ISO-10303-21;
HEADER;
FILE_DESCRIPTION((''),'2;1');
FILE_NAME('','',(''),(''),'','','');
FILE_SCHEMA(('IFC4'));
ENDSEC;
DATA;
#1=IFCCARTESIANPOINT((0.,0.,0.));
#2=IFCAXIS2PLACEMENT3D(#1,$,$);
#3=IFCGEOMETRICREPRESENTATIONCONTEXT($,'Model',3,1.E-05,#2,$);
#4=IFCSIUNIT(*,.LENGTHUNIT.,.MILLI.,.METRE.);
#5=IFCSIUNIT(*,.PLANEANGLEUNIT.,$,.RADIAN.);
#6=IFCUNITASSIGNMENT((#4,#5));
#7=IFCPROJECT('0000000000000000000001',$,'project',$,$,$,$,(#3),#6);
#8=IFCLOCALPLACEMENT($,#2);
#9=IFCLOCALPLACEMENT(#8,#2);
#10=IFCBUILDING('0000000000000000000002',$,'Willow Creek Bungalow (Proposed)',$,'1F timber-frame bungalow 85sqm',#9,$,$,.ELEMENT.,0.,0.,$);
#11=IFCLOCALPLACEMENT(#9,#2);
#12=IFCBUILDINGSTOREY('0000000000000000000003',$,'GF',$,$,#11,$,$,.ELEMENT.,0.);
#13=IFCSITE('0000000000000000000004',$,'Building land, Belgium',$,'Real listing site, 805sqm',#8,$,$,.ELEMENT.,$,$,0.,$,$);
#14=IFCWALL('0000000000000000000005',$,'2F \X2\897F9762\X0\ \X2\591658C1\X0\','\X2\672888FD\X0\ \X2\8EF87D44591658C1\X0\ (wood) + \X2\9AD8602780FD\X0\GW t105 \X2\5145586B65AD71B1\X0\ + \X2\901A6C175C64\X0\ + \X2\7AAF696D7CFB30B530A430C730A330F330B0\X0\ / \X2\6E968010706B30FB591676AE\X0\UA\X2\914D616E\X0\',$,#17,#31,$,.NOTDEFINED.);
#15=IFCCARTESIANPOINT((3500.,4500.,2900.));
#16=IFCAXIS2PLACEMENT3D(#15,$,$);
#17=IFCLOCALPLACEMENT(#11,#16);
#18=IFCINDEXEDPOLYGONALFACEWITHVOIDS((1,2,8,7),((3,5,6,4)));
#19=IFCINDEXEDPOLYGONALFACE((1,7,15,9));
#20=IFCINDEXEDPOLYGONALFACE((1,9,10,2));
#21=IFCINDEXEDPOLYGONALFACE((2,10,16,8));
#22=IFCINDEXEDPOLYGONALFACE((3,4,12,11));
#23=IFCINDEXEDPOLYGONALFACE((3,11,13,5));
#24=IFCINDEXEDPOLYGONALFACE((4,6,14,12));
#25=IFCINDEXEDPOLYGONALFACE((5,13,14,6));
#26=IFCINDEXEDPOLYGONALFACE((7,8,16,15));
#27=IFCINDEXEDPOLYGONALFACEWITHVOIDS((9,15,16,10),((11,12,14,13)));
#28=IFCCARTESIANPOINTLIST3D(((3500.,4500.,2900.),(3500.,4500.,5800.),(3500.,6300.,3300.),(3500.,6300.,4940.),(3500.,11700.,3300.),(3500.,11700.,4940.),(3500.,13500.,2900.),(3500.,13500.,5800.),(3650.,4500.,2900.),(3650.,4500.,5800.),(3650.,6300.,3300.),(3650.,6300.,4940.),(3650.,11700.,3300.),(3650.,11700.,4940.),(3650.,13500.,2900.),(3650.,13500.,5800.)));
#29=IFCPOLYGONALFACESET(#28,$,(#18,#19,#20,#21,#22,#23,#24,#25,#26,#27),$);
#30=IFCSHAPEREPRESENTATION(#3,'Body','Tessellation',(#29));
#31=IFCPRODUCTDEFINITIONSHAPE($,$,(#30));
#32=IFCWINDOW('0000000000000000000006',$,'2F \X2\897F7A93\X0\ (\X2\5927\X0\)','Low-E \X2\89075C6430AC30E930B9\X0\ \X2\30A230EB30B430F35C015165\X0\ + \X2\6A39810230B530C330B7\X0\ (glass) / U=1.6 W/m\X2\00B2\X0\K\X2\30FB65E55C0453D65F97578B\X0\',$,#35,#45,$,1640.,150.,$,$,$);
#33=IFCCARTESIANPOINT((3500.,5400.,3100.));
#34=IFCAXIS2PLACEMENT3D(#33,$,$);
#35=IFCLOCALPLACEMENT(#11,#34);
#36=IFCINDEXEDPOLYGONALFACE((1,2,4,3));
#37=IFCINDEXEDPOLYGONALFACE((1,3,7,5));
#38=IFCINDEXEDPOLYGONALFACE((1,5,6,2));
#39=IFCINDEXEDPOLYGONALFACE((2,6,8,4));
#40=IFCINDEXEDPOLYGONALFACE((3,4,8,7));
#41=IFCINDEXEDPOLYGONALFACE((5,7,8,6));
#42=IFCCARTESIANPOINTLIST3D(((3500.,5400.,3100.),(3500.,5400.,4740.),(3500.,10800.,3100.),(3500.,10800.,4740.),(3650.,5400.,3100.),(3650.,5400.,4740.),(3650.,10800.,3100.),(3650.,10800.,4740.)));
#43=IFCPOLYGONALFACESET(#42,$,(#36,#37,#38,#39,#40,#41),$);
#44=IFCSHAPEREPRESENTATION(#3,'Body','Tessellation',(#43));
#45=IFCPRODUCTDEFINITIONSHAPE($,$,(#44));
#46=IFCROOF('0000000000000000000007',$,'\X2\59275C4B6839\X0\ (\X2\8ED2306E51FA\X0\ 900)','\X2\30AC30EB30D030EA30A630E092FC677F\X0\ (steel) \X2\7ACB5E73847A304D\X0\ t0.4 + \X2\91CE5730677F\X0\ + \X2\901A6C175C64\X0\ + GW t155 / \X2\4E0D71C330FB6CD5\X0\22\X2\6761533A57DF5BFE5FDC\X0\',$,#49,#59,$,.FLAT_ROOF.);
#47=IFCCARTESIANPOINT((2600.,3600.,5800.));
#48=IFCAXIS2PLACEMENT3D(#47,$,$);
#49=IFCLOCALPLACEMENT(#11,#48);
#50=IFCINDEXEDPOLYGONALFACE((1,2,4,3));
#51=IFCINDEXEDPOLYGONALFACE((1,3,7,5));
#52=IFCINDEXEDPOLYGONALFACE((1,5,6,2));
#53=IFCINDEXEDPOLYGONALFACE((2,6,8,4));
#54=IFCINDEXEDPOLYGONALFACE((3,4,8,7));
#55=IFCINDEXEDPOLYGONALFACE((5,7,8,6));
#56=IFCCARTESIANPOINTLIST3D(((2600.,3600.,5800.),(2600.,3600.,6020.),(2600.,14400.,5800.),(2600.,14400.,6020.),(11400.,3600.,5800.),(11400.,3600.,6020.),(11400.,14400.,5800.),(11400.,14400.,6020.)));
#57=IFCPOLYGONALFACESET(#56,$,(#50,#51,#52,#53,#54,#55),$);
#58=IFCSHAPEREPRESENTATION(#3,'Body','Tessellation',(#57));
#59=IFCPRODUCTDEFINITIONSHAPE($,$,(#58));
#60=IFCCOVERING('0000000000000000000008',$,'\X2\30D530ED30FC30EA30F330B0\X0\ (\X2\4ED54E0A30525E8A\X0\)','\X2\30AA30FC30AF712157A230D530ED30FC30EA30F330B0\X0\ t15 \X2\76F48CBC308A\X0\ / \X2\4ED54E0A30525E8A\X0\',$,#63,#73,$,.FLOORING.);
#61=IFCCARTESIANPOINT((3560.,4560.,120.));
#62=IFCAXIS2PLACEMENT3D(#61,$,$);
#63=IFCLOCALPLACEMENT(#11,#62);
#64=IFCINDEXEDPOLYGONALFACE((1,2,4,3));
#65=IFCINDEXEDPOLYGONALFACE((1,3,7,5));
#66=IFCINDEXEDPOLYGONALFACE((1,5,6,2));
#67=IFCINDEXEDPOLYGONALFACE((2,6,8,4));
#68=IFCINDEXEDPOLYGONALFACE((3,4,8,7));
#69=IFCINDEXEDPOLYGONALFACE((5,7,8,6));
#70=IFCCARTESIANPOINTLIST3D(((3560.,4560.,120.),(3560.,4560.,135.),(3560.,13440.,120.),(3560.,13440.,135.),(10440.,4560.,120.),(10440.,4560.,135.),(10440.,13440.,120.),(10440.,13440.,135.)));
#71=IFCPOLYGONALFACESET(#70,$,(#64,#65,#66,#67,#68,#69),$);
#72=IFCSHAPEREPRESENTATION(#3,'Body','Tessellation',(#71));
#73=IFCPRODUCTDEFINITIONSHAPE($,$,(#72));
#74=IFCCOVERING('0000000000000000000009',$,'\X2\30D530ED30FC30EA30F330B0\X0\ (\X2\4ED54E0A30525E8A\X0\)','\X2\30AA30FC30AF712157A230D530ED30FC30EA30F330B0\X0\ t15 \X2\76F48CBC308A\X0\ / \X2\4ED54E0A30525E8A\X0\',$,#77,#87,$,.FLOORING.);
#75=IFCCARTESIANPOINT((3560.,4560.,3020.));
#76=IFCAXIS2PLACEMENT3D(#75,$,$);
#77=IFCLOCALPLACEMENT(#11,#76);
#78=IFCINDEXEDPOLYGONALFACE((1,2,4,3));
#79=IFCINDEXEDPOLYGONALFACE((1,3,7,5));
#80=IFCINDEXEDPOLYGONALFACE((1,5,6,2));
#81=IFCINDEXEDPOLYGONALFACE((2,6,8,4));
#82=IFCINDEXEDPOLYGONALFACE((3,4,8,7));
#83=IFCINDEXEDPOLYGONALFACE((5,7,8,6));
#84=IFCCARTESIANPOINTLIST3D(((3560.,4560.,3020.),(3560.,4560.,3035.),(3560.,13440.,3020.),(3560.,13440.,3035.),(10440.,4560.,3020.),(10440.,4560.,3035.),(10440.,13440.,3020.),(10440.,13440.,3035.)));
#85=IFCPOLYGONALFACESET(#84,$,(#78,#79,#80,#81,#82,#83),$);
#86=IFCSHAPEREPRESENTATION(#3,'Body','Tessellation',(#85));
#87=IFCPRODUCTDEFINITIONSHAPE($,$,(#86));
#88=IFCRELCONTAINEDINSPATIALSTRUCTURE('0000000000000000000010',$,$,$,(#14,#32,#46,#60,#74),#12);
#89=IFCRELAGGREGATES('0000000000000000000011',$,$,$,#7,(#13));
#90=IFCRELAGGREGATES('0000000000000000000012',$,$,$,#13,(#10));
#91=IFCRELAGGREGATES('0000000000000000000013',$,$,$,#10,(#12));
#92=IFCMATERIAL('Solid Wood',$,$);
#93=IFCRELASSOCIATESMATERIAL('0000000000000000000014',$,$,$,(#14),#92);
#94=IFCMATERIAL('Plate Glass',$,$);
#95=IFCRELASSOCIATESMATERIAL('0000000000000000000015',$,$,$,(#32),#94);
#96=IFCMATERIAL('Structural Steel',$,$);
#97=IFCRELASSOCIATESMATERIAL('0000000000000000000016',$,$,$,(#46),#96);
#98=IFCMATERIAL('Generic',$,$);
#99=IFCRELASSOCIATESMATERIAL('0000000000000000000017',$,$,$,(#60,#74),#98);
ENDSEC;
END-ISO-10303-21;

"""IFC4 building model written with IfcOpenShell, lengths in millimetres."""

from ifc_helpers import new_model, si_unit, frame, frame_2d, origin, place, context, project, spatial, rectangle, extrude, material, element, fill, save


model = new_model("IFC4")

# Units and contexts
model_context = context("Model", 3, precision=1e-05, world=origin())
ifc_project = project(units=[si_unit("LENGTHUNIT", "METRE", prefix="MILLI"), si_unit("PLANEANGLEUNIT", "RADIAN")], contexts=[model_context])

# Site, building, storey
site_placement = place(None, origin())
site = spatial("IfcSite", under=ifc_project, at=site_placement, Name="Building land, Belgium", ObjectType="Real listing site, 805sqm", CompositionType="ELEMENT", RefElevation=0.0)
building_placement = place(site_placement, origin())
building = spatial("IfcBuilding", under=site, at=building_placement, Name="Willow Creek Bungalow (Proposed)", ObjectType="1F timber-frame bungalow 85sqm", CompositionType="ELEMENT", ElevationOfRefHeight=0.0, ElevationOfTerrain=0.0)
storey_placement = place(building_placement, origin())
storey = spatial("IfcBuildingStorey", under=building, at=storey_placement, Name="GF", CompositionType="ELEMENT", Elevation=0.0)

# Shared definitions
ifc_material_1 = material(Name="Solid Wood")
ifc_material_2 = material(Name="Generic")

# Shared definitions
ifc_material_3 = material(Name="Plate Glass")

# Wall, opening, window
wall_1_placement = place(storey_placement, frame((3500.0, 4500.0, 2900.0)))
wall_1 = element("IfcWall", 1, at=wall_1_placement, inside=storey, material=ifc_material_1, Name="2F 西面 外壁", Description="木製 軸組外壁 (wood) + 高性能GW t105 充填断熱 + 通気層 + 窯業系サイディング / 準耐火・外皮UA配慮", PredefinedType="NOTDEFINED", context=model_context, shape_type="SweptSolid", body=[
    extrude(rectangle(XDim=150.0, YDim=9000.0, at=frame_2d((75.0, 4500.0))), frame((3500.0, 4500.0, 2900.0)), (0.0, 0.0, 1.0), 2900.0),
])
opening_1_placement = place(storey_placement, frame((3500.0, 5400.0, 3100.0)))
opening_1 = element("IfcOpeningElement", 2, at=opening_1_placement, cuts=wall_1, PredefinedType="NOTDEFINED", context=model_context, shape_type="SweptSolid", body=[
    extrude(rectangle(XDim=150.0, YDim=5400.0, at=frame_2d((75.0, 2700.0))), frame((3500.0, 5400.0, 3100.0)), (0.0, 0.0, 1.0), 1640.0),
])
window_1_placement = place(storey_placement, frame((3500.0, 5400.0, 3100.0)))
window_1 = element("IfcWindow", 3, at=window_1_placement, inside=storey, material=ifc_material_3, Name="2F 西窓 (大)", Description="Low-E 複層ガラス アルゴン封入 + 樹脂サッシ (glass) / U=1.6 W/m²K・日射取得型", OverallHeight=1640.0, OverallWidth=150.0, context=model_context, shape_type="SweptSolid", body=[
    extrude(rectangle(XDim=150.0, YDim=5400.0, at=frame_2d((75.0, 2700.0))), frame((3500.0, 5400.0, 3100.0)), (0.0, 0.0, 1.0), 1640.0),
])
fill(opening_1, window_1)

# Roof
ifc_material_4 = material(Name="Structural Steel")
roof_placement = place(storey_placement, frame((2600.0, 3600.0, 5800.0)))
element("IfcRoof", 4, at=roof_placement, inside=storey, material=ifc_material_4, Name="大屋根 (軒の出 900)", Description="ガルバリウム鋼板 (steel) 立平葺き t0.4 + 野地板 + 通気層 + GW t155 / 不燃・法22条区域対応", PredefinedType="FLAT_ROOF", context=model_context, shape_type="SweptSolid", body=[
    extrude(rectangle(XDim=8800.0, YDim=10800.0, at=frame_2d((4400.0, 5400.0))), frame((2600.0, 3600.0, 5800.0)), (0.0, 0.0, 1.0), 220.0),
])

# Coverings
covering_1_placement = place(storey_placement, frame((3560.0, 4560.0, 120.0)))
element("IfcCovering", 5, at=covering_1_placement, inside=storey, material=ifc_material_2, Name="フローリング (仕上げ床)", Description="オーク無垢フローリング t15 直貼り / 仕上げ床", PredefinedType="FLOORING", context=model_context, shape_type="SweptSolid", body=[
    extrude(rectangle(XDim=6880.0, YDim=8880.0, at=frame_2d((3440.0, 4440.0))), frame((3560.0, 4560.0, 120.0)), (0.0, 0.0, 1.0), 15.0),
])
covering_2_placement = place(storey_placement, frame((3560.0, 4560.0, 3020.0)))
element("IfcCovering", 6, at=covering_2_placement, inside=storey, material=ifc_material_2, Name="フローリング (仕上げ床)", Description="オーク無垢フローリング t15 直貼り / 仕上げ床", PredefinedType="FLOORING", context=model_context, shape_type="SweptSolid", body=[
    extrude(rectangle(XDim=6880.0, YDim=8880.0, at=frame_2d((3440.0, 4440.0))), frame((3560.0, 4560.0, 3020.0)), (0.0, 0.0, 1.0), 15.0),
])

save(model, "model.ifc")
